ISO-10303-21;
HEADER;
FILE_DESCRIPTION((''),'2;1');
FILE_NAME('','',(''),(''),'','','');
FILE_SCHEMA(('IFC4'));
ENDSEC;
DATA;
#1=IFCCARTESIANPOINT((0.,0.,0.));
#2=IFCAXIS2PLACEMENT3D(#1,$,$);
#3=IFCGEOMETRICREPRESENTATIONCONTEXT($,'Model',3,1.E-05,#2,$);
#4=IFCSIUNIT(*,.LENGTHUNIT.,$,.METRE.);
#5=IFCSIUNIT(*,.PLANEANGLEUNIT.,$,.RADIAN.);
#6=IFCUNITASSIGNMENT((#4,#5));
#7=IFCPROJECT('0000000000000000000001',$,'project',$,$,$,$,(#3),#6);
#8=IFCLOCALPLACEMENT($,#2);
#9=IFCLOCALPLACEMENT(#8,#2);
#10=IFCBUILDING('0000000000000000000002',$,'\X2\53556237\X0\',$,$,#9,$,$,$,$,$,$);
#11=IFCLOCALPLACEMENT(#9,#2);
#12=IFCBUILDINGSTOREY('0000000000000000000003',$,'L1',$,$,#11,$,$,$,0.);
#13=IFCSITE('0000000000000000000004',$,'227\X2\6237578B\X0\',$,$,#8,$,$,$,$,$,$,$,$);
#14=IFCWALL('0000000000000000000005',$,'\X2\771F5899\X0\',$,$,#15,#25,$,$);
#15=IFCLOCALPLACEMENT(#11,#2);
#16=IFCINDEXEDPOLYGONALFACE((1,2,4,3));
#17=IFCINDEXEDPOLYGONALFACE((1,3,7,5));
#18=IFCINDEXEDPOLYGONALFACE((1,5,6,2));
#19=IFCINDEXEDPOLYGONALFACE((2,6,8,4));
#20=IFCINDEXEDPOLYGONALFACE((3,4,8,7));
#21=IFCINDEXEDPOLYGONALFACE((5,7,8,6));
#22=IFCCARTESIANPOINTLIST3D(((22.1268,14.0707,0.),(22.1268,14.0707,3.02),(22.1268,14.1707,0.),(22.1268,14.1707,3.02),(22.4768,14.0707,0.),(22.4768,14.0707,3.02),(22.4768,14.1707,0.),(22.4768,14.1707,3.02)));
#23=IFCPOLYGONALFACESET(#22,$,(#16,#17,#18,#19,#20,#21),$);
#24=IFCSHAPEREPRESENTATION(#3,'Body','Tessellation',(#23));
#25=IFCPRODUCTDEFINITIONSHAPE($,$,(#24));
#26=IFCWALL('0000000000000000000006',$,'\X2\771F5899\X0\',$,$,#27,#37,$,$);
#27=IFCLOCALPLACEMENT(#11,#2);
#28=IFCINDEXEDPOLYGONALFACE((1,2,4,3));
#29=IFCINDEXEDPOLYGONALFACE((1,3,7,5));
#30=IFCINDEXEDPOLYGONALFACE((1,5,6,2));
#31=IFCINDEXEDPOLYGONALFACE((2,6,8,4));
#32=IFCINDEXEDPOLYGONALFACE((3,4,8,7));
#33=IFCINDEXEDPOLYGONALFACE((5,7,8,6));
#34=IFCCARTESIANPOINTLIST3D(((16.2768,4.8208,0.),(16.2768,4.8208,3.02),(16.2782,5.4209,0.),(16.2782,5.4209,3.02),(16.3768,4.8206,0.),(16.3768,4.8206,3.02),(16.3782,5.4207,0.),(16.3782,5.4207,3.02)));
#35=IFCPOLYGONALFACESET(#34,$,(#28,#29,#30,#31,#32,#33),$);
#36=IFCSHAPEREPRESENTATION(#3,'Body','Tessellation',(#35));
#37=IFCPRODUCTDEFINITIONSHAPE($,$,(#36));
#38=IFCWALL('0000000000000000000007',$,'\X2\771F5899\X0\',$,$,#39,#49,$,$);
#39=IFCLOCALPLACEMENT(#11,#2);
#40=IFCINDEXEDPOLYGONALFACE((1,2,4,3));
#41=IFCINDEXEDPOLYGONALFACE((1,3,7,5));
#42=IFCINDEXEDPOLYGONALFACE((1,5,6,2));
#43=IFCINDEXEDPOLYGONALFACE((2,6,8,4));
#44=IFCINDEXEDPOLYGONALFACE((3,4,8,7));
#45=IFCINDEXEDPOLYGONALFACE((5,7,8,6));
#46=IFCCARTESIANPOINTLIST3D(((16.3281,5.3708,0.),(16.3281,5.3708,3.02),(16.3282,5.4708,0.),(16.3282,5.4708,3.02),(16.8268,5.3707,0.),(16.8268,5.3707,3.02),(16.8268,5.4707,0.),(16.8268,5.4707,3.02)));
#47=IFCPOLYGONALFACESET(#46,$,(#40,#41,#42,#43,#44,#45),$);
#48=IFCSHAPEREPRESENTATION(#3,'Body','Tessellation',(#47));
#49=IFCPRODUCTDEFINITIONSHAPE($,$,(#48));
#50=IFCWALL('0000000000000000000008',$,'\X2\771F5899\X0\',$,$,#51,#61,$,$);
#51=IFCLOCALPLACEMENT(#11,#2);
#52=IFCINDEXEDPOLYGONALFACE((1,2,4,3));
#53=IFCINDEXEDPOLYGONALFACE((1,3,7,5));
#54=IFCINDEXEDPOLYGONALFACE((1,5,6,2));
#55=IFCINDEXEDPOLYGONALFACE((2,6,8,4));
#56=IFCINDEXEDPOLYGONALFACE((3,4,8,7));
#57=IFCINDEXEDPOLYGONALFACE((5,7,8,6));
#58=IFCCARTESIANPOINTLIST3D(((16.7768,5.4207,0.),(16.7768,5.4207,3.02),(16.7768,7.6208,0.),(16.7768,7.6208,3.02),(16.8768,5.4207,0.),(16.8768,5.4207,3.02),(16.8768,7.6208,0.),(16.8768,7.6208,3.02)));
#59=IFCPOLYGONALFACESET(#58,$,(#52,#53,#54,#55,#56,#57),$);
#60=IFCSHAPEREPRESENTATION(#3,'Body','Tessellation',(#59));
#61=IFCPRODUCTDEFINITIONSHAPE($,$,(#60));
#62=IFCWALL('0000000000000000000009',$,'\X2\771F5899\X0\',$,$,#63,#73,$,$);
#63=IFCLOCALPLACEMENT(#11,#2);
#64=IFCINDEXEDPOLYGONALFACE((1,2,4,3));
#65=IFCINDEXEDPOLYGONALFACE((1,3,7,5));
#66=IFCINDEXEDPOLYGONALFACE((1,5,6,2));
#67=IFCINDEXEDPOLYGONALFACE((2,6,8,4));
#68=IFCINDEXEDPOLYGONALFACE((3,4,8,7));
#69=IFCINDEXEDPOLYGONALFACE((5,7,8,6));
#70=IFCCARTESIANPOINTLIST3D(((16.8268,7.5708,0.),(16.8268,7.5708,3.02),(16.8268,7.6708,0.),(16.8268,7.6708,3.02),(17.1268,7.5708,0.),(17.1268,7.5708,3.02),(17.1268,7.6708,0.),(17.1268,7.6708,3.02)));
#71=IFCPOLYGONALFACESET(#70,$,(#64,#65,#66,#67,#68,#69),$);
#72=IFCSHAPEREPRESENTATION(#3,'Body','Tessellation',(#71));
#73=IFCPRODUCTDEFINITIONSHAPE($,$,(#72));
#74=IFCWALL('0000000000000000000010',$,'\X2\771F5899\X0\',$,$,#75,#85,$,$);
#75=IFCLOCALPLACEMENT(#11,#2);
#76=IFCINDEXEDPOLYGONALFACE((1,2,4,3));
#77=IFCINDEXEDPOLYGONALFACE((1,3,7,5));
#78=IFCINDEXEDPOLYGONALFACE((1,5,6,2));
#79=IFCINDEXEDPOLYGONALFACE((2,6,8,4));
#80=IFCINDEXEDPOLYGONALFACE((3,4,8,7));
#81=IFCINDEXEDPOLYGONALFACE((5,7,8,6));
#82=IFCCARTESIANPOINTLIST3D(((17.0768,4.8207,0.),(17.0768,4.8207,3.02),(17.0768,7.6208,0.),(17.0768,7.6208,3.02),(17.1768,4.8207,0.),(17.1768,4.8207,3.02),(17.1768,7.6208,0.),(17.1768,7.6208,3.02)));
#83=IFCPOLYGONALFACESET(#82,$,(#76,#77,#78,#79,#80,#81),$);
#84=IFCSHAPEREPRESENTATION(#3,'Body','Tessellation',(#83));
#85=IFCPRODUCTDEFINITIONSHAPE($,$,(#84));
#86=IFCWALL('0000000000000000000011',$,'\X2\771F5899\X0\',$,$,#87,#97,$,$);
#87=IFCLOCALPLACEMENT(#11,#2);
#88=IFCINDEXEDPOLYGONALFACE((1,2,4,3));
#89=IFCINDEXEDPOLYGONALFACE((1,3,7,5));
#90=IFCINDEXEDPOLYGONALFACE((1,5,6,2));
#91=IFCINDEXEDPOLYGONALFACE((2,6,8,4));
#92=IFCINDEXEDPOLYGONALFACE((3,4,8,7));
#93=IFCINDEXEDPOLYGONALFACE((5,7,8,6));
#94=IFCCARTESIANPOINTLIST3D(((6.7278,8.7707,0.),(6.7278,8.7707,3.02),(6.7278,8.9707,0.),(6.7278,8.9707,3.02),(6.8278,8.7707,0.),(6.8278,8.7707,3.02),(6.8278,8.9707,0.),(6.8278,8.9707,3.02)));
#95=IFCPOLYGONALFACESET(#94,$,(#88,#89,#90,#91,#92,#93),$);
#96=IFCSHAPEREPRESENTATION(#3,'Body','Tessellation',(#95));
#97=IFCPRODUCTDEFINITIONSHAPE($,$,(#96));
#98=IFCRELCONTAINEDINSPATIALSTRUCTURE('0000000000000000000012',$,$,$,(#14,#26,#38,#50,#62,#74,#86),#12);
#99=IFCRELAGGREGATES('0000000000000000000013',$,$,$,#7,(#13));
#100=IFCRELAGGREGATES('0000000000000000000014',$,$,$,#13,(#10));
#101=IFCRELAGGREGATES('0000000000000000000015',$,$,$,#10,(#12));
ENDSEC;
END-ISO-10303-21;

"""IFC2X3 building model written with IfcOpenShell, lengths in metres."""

from ifc_helpers import new_model, si_unit, origin, place, context, project, spatial, polyline, outline, extrude, element, save


model = new_model("IFC2X3")

# Units and contexts
model_context = context("Model", 3, precision=1e-05, world=origin())
ifc_project = project(units=[si_unit("LENGTHUNIT", "METRE"), si_unit("PLANEANGLEUNIT", "RADIAN")], contexts=[model_context])

# Site, building, storey
site_placement = place(None, origin())
site = spatial("IfcSite", under=ifc_project, at=site_placement, Name="227户型")
building_placement = place(site_placement, origin())
building = spatial("IfcBuilding", under=site, at=building_placement, Name="单户")
storey_placement = place(building_placement, origin())
storey = spatial("IfcBuildingStorey", under=building, at=storey_placement, Name="L1", Elevation=0.0)

# Walls
wall_1_placement = place(storey_placement, origin())
element("IfcWall", 1, at=wall_1_placement, inside=storey, Name="真墙", context=model_context, shape_type="SweptSolid", body=[
    extrude(outline(polyline([(22.4768, 14.0707), (22.1268, 14.0707), (22.1268, 14.1707), (22.4768, 14.1707), (22.4768, 14.0707)])), origin(), (0.0, 0.0, 1.0), 3.02),
])
wall_2_placement = place(storey_placement, origin())
element("IfcWall", 2, at=wall_2_placement, inside=storey, Name="真墙", context=model_context, shape_type="SweptSolid", body=[
    extrude(outline(polyline([(16.2768, 4.8208), (16.2782, 5.4209), (16.3782, 5.4207), (16.3768, 4.8206), (16.2768, 4.8208)])), origin(), (0.0, 0.0, 1.0), 3.02),
])
wall_3_placement = place(storey_placement, origin())
element("IfcWall", 3, at=wall_3_placement, inside=storey, Name="真墙", context=model_context, shape_type="SweptSolid", body=[
    extrude(outline(polyline([(16.3282, 5.4708), (16.8268, 5.4707), (16.8268, 5.3707), (16.3281, 5.3708), (16.3282, 5.4708)])), origin(), (0.0, 0.0, 1.0), 3.02),
])
wall_4_placement = place(storey_placement, origin())
element("IfcWall", 4, at=wall_4_placement, inside=storey, Name="真墙", context=model_context, shape_type="SweptSolid", body=[
    extrude(outline(polyline([(16.7768, 5.4207), (16.7768, 7.6208), (16.8768, 7.6208), (16.8768, 5.4207), (16.7768, 5.4207)])), origin(), (0.0, 0.0, 1.0), 3.02),
])
wall_5_placement = place(storey_placement, origin())
element("IfcWall", 5, at=wall_5_placement, inside=storey, Name="真墙", context=model_context, shape_type="SweptSolid", body=[
    extrude(outline(polyline([(16.8268, 7.6708), (17.1268, 7.6708), (17.1268, 7.5708), (16.8268, 7.5708), (16.8268, 7.6708)])), origin(), (0.0, 0.0, 1.0), 3.02),
])
wall_6_placement = place(storey_placement, origin())
element("IfcWall", 6, at=wall_6_placement, inside=storey, Name="真墙", context=model_context, shape_type="SweptSolid", body=[
    extrude(outline(polyline([(17.1768, 7.6208), (17.1768, 4.8207), (17.0768, 4.8207), (17.0768, 7.6208), (17.1768, 7.6208)])), origin(), (0.0, 0.0, 1.0), 3.02),
])

# Wall
wall_7_placement = place(storey_placement, origin())
element("IfcWall", 7, at=wall_7_placement, inside=storey, Name="真墙", context=model_context, shape_type="SweptSolid", body=[
    extrude(outline(polyline([(6.8278, 8.9707), (6.8278, 8.7707), (6.7278, 8.7707), (6.7278, 8.9707), (6.8278, 8.9707)])), origin(), (0.0, 0.0, 1.0), 3.02),
])

save(model, "model.ifc")
